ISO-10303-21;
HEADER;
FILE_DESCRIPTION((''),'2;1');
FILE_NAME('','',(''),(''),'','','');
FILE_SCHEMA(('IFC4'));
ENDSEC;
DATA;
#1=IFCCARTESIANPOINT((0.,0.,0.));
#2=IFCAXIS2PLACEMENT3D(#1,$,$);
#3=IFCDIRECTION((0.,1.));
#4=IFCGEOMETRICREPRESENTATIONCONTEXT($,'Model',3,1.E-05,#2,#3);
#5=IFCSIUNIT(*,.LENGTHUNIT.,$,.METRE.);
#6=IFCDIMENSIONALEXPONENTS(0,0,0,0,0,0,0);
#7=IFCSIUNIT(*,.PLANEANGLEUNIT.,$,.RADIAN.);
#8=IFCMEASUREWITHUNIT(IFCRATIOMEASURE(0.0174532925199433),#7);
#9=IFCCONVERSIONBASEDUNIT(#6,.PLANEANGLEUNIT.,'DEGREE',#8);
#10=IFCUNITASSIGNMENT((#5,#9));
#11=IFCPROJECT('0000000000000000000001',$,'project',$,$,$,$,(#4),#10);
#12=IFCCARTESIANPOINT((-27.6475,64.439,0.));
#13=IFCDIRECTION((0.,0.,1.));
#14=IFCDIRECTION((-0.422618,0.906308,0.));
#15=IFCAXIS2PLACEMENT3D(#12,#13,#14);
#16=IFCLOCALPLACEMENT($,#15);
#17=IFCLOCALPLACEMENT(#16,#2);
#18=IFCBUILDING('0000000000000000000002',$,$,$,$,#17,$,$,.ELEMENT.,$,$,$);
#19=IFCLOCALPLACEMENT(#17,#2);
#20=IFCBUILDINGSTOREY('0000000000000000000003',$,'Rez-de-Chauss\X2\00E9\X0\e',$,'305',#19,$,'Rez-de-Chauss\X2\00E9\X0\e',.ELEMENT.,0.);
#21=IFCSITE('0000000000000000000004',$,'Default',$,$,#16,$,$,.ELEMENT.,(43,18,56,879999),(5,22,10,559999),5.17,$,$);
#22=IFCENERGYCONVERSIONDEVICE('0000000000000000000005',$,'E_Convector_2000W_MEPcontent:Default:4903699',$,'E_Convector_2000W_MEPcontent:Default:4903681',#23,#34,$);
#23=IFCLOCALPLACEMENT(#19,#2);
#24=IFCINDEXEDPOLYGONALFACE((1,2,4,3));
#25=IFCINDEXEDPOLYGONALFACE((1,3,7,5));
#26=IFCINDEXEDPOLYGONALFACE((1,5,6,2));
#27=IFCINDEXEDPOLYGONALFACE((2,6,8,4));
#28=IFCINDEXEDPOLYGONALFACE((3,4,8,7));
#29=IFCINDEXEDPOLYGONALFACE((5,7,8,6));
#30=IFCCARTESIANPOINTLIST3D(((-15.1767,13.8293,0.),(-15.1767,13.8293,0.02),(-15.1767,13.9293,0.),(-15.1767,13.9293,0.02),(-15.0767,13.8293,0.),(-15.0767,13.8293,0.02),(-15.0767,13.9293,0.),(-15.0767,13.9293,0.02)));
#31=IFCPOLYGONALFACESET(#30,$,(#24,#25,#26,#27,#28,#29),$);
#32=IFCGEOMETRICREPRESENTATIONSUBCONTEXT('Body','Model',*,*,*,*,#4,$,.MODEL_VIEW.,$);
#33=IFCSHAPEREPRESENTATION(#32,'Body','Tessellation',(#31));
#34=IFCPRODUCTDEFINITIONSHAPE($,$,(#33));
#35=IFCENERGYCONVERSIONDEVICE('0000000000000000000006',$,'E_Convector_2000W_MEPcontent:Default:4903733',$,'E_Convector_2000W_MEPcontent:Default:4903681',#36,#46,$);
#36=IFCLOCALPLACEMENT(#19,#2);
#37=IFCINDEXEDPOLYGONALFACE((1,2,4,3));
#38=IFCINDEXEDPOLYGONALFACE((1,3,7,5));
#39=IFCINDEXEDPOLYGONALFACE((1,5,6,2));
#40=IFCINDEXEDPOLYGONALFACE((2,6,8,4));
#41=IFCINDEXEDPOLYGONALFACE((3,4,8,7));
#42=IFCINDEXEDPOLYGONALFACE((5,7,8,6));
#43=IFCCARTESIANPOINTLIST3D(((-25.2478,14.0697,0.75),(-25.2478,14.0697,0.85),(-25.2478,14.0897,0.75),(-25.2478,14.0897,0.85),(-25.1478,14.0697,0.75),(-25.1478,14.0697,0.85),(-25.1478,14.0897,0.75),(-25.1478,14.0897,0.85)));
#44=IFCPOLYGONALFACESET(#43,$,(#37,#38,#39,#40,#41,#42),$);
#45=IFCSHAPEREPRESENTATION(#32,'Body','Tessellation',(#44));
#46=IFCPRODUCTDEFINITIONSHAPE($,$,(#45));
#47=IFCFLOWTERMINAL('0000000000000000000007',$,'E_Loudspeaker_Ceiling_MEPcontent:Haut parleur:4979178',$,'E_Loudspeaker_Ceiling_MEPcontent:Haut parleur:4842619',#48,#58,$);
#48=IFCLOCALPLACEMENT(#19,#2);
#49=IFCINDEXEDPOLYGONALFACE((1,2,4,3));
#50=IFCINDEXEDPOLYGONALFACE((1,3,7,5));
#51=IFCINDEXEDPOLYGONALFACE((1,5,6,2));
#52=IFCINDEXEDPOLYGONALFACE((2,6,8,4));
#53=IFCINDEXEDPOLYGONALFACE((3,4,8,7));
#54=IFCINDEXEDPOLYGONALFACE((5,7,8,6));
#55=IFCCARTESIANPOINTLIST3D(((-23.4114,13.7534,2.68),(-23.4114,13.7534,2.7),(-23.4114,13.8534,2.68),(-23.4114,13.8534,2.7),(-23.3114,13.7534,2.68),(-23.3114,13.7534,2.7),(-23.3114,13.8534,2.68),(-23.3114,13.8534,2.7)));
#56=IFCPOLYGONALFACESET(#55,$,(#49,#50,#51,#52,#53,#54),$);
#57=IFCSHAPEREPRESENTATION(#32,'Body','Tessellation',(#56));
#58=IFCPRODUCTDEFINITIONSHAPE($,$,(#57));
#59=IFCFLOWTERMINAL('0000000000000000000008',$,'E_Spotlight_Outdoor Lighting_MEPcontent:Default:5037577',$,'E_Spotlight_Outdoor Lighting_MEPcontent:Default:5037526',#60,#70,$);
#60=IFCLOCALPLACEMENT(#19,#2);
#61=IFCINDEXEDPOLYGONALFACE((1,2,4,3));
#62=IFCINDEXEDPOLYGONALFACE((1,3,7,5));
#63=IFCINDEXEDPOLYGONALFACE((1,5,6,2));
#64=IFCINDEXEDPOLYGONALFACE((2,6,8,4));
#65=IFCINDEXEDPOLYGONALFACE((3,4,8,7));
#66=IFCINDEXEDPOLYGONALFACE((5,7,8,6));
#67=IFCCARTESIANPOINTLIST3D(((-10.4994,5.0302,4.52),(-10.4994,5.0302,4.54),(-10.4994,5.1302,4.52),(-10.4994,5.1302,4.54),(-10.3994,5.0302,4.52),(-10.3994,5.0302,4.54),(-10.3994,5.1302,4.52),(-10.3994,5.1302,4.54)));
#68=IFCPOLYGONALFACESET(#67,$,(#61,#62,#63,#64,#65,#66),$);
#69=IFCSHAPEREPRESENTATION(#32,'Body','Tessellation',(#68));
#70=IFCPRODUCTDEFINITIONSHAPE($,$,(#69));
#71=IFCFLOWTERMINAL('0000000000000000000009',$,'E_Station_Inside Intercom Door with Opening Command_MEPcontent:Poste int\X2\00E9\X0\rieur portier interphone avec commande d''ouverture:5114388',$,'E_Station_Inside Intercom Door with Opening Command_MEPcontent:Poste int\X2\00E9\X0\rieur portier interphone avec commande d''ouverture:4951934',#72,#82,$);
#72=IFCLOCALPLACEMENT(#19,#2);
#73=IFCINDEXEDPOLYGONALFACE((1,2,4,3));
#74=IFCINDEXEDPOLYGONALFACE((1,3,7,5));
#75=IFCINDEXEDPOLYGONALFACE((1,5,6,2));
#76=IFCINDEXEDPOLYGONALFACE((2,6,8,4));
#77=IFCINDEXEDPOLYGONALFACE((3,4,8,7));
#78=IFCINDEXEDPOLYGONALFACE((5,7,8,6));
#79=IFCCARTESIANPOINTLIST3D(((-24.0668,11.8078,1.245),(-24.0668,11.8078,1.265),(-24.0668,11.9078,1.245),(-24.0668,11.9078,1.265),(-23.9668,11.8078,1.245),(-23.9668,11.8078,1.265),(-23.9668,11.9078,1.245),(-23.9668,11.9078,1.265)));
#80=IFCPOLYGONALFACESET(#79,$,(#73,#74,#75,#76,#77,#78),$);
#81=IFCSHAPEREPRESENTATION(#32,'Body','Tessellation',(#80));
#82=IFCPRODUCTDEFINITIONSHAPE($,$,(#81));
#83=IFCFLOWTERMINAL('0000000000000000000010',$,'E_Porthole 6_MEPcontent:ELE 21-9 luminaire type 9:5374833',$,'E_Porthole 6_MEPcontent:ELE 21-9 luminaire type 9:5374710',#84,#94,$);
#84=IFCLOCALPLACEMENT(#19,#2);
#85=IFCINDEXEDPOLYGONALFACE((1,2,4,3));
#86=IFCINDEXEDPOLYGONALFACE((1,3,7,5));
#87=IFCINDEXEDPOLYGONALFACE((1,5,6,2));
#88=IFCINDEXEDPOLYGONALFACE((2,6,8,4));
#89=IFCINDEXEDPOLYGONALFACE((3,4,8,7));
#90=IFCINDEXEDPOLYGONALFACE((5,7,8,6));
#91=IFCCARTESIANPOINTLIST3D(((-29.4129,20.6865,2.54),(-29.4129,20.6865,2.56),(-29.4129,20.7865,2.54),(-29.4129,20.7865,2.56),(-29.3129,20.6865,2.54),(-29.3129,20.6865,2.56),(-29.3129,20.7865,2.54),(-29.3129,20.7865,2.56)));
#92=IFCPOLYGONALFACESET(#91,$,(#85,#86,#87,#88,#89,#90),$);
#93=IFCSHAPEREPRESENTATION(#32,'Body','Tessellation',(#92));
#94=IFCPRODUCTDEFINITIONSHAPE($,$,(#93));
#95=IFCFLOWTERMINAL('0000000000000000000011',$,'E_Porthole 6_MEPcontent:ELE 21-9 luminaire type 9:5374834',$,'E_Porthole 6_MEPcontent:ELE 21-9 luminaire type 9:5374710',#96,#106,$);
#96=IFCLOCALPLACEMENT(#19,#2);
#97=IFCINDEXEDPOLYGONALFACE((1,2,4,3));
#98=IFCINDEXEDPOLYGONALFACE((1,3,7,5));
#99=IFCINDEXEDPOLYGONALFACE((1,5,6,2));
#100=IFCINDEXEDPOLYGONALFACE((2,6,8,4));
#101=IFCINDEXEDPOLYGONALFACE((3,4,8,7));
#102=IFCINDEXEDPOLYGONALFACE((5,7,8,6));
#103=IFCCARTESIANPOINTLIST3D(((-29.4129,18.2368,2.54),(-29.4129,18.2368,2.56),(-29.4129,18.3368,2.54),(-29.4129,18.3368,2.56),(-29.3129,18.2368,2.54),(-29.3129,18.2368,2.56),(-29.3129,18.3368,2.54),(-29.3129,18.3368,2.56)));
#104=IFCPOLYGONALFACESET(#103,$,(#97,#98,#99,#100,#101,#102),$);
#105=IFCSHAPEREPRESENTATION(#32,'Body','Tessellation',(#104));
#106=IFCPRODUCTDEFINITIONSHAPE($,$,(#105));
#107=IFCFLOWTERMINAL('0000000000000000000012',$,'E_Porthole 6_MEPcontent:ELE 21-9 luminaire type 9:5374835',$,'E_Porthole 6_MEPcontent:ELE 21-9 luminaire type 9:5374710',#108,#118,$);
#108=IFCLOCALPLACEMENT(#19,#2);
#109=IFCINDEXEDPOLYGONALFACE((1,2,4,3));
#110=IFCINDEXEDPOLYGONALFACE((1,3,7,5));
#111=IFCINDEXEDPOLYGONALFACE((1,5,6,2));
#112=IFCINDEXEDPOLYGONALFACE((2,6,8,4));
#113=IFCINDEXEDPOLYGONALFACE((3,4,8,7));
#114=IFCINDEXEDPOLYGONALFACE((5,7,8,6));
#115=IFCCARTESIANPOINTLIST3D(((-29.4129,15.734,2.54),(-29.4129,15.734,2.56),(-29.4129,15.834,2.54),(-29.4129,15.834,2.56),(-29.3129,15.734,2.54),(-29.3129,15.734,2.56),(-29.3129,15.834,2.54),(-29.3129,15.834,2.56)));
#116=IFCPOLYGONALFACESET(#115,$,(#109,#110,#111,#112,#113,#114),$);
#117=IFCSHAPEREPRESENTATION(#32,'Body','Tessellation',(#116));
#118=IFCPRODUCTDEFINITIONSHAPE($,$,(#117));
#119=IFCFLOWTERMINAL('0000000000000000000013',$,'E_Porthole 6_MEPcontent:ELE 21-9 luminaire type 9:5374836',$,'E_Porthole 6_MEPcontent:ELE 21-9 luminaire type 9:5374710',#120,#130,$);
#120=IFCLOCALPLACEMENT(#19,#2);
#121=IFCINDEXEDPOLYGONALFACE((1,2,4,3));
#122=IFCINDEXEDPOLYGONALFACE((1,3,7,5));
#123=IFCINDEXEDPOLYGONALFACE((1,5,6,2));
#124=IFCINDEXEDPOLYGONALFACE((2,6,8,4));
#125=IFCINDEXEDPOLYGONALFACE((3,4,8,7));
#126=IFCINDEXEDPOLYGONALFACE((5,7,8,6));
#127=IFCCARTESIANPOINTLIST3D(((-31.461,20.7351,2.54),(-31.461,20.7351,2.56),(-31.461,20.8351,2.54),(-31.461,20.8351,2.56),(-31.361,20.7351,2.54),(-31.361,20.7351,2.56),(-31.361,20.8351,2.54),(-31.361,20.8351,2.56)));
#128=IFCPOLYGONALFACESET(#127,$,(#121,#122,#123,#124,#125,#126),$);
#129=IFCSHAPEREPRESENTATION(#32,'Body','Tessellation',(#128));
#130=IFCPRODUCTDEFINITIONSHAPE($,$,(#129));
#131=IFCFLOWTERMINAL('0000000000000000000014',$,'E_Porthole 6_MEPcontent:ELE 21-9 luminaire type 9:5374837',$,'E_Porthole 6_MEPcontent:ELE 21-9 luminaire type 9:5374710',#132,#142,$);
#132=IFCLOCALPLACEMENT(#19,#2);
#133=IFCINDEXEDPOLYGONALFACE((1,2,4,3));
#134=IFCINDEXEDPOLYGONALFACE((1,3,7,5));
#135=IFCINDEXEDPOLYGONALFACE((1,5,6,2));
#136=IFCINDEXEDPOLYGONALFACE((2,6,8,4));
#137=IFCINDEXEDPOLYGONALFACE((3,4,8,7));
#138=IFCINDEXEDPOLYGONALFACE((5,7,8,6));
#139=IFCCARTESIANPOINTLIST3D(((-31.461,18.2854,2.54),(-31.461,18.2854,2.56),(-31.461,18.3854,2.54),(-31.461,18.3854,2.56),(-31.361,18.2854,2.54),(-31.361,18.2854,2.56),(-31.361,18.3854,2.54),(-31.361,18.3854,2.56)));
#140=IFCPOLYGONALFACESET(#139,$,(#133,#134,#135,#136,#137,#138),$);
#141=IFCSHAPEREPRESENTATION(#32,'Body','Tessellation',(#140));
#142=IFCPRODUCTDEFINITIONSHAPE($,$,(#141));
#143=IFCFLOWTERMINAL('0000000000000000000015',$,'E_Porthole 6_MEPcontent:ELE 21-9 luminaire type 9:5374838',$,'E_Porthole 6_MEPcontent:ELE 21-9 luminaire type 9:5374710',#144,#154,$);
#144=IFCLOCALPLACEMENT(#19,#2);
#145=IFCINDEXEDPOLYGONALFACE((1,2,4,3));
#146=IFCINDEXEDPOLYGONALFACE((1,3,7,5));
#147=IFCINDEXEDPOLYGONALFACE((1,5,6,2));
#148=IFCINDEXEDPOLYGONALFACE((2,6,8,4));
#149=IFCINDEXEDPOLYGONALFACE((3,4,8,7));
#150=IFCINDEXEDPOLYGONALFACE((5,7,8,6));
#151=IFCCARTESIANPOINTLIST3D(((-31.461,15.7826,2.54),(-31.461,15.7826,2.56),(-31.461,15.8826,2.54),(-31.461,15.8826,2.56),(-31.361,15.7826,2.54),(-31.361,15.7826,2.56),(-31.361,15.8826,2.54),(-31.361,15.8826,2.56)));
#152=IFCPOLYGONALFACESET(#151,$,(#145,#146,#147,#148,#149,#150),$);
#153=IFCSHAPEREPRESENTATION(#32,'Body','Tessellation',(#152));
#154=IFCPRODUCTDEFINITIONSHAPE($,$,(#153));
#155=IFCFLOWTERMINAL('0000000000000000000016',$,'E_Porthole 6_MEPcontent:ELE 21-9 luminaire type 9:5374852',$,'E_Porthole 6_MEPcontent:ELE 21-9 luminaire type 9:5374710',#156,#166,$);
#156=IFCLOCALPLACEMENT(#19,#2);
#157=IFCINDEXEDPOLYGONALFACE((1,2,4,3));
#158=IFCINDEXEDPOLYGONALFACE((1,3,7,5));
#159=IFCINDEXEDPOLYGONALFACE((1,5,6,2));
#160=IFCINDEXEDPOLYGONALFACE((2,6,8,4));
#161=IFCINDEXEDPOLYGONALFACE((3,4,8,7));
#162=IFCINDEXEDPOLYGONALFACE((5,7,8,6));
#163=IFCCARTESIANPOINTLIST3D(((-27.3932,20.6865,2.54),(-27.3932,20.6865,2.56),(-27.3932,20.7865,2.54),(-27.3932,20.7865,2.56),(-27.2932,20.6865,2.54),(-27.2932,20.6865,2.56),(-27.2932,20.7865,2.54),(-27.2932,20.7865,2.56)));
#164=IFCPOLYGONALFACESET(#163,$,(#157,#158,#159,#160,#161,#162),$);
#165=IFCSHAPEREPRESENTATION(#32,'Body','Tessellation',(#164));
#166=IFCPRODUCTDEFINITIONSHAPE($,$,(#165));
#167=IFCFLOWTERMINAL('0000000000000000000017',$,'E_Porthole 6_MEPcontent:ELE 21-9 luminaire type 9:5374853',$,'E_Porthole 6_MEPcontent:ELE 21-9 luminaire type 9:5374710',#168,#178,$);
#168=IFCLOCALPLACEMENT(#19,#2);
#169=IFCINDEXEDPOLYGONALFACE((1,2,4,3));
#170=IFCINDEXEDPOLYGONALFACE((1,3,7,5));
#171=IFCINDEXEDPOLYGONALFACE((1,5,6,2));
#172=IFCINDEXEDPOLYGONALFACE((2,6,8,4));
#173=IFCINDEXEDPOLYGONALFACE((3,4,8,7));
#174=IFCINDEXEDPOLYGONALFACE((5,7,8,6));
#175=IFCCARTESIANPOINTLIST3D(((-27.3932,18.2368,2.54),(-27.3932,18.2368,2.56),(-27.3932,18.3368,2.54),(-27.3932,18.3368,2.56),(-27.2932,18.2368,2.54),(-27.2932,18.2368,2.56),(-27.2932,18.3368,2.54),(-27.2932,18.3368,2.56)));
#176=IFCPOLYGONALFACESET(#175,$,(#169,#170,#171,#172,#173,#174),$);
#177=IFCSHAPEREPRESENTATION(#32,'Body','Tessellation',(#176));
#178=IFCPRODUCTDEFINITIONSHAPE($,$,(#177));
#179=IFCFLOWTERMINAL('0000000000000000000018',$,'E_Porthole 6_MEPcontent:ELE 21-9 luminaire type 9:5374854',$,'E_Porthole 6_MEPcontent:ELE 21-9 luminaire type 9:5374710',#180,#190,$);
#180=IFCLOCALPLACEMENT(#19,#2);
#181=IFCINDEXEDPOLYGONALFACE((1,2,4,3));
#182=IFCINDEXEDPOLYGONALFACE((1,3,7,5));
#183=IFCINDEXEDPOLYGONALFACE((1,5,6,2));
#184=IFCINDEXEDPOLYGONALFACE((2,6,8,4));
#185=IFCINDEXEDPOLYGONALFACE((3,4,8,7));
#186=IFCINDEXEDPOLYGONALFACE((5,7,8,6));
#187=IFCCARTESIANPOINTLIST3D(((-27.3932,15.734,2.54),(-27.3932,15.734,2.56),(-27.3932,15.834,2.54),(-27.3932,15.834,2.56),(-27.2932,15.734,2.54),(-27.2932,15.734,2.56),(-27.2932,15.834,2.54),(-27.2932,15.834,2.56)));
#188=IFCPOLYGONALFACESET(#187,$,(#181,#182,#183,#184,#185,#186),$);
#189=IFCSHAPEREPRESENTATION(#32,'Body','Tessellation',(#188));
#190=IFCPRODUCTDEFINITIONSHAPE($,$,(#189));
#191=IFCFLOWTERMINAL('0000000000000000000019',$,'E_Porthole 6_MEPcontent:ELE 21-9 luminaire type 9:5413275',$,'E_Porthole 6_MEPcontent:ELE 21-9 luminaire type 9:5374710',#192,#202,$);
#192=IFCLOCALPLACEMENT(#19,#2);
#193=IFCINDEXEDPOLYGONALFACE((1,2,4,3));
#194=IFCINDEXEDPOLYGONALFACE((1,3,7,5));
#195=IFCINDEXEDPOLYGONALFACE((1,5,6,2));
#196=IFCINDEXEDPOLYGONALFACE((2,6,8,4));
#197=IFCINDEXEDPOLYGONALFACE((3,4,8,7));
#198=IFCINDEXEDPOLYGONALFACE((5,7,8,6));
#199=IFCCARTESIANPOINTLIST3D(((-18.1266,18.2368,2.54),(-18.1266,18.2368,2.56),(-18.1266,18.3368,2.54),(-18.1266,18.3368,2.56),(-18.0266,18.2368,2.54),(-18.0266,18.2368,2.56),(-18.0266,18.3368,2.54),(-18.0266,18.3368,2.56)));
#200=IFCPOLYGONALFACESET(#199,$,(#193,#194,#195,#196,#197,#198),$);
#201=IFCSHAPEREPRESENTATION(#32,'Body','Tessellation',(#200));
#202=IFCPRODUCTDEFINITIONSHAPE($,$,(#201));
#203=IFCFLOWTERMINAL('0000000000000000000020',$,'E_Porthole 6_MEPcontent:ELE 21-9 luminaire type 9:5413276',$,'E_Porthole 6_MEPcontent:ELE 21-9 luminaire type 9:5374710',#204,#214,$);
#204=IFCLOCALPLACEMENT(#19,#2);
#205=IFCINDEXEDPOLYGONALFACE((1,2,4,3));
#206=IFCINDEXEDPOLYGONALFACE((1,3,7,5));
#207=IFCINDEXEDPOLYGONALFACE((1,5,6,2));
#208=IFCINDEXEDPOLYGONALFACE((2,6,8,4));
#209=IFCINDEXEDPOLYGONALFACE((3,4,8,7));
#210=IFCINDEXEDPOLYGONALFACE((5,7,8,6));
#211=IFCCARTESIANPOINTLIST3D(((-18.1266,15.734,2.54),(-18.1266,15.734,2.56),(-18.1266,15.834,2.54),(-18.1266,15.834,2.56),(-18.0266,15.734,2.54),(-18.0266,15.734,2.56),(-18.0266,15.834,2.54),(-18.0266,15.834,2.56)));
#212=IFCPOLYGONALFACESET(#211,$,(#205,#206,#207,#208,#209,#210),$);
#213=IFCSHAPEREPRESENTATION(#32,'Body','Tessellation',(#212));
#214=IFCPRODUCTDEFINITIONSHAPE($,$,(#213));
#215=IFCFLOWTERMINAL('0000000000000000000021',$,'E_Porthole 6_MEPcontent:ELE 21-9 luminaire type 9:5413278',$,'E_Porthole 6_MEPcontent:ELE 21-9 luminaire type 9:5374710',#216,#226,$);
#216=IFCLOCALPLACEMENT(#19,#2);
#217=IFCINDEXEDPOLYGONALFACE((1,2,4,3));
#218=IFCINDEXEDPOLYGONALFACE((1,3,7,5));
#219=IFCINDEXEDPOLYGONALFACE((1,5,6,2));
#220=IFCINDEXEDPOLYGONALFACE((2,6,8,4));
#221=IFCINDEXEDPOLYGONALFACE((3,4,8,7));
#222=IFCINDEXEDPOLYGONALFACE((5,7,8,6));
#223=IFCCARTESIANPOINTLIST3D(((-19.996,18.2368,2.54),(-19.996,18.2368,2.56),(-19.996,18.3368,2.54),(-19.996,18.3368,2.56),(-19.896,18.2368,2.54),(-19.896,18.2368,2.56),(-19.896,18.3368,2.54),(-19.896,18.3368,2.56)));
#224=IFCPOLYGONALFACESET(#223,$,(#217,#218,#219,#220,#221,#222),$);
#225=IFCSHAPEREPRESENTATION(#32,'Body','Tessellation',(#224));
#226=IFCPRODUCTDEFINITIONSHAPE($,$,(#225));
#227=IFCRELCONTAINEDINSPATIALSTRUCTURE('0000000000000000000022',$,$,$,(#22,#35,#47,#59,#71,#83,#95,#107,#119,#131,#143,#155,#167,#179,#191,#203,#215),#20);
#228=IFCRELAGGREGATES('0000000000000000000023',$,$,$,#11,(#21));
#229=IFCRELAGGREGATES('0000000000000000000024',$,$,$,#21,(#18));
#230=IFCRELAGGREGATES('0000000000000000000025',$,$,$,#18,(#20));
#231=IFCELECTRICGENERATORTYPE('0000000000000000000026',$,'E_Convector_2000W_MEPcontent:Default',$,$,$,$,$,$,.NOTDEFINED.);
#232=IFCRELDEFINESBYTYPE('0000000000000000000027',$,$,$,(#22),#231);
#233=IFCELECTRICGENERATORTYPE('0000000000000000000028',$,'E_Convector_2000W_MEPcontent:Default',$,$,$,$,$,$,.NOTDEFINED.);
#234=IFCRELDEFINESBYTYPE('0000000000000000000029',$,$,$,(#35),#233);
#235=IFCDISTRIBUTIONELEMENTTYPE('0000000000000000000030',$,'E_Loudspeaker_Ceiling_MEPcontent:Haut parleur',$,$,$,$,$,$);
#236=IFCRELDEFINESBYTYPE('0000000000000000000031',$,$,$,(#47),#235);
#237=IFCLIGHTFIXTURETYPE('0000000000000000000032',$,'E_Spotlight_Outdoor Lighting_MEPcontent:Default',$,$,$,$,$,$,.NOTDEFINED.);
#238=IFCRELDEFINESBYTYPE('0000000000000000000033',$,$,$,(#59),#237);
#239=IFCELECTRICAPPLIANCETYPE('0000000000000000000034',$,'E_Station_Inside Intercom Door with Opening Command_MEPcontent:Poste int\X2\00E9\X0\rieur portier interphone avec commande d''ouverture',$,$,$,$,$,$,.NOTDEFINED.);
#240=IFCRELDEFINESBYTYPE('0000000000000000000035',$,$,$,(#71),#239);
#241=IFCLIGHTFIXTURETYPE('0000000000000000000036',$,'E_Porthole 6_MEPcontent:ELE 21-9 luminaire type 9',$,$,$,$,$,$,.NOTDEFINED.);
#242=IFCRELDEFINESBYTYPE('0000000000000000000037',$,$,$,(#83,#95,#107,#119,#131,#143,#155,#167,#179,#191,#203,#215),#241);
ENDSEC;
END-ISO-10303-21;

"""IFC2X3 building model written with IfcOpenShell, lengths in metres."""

from ifc_helpers import new_model, entity, si_unit, converted_unit, direction, frame, frame_2d, origin, origin_2d_with_axis, place, context, subcontext, project, spatial, rectangle, extrude, source, transform, mapped, type_object, type_shapes, element, save


model = new_model("IFC2X3")

# Units and contexts
model_context = context("Model", 3, precision=1e-05, world=origin(), true_north=direction((0.0, 1.0)))
body_context = subcontext(model_context, "Body", "Model", "MODEL_VIEW")
ifc_project = project(units=[si_unit("LENGTHUNIT", "METRE"), converted_unit("PLANEANGLEUNIT", "DEGREE", entity("IfcRatioMeasure", 0.0174532925199433), si_unit("PLANEANGLEUNIT", "RADIAN"), dimensions=[0, 0, 0, 0, 0, 0, 0])], contexts=[model_context])

# Site, building, storey
site_placement = place(None, frame((-27.6475, 64.439, 0.0), z_axis=(0.0, 0.0, 1.0), x_axis=(-0.422618, 0.906308, 0.0)))
site = spatial("IfcSite", under=ifc_project, at=site_placement, Name="Default", CompositionType="ELEMENT", RefLatitude=(43, 18, 56, 879999), RefLongitude=(5, 22, 10, 559999), RefElevation=5.17)
building_placement = place(site_placement, origin())
building = spatial("IfcBuilding", under=site, at=building_placement, CompositionType="ELEMENT")
storey_placement = place(building_placement, origin())
storey = spatial("IfcBuildingStorey", under=building, at=storey_placement, Name="Rez-de-Chaussée", ObjectType="305", LongName="Rez-de-Chaussée", CompositionType="ELEMENT", Elevation=0.0)

# Energy conversion devices
electric_generator_type_1 = type_object("IfcElectricGeneratorType", Name="E_Convector_2000W_MEPcontent:Default", PredefinedType="NOTDEFINED")
shared_shape_1 = source(origin(), body_context, "Body", "SweptSolid", [
    extrude(rectangle(XDim=0.1, YDim=0.1, at=origin_2d_with_axis()), frame((0.0, 0.0, 0.0), z_axis=(0.0, 0.0, 1.0), x_axis=(0.0, -1.0, 0.0)), (0.0, 0.0, 1.0), 0.02),
])
type_shapes(electric_generator_type_1, [shared_shape_1])
energy_conversion_device_1_placement = place(storey_placement, frame((-15.1267, 13.8793, 0.0)))
element("IfcEnergyConversionDevice", 1, at=energy_conversion_device_1_placement, inside=storey, type_object=electric_generator_type_1, Name="E_Convector_2000W_MEPcontent:Default:4903699", ObjectType="E_Convector_2000W_MEPcontent:Default:4903681", context=body_context, shape_type="MappedRepresentation", body=[
    mapped(shared_shape_1, transform((0.0, 0.0, 0.0), scale=1.0)),
])
electric_generator_type_2 = type_object("IfcElectricGeneratorType", Name="E_Convector_2000W_MEPcontent:Default", PredefinedType="NOTDEFINED")
shared_shape_2 = source(origin(), body_context, "Body", "SweptSolid", [
    extrude(rectangle(XDim=0.02, YDim=0.1, at=frame_2d((0.0, 0.0), x_axis=(1.0, 0.0))), frame((0.0, 0.01, -0.05), z_axis=(0.0, 0.0, 1.0), x_axis=(0.0, -1.0, 0.0)), (0.0, 0.0, 1.0), 0.1),
])
type_shapes(electric_generator_type_2, [shared_shape_2])
energy_conversion_device_2_placement = place(storey_placement, frame((-25.1978, 14.0897, 0.8), z_axis=(0.0, 0.0, 1.0), x_axis=(-1.0, 0.0, 0.0)))
element("IfcEnergyConversionDevice", 2, at=energy_conversion_device_2_placement, inside=storey, type_object=electric_generator_type_2, Name="E_Convector_2000W_MEPcontent:Default:4903733", ObjectType="E_Convector_2000W_MEPcontent:Default:4903681", context=body_context, shape_type="MappedRepresentation", body=[
    mapped(shared_shape_2, transform((0.0, 0.0, 0.0), scale=1.0)),
])

# Flow terminals
distribution_element_type_1 = type_object("IfcDistributionElementType", Name="E_Loudspeaker_Ceiling_MEPcontent:Haut parleur")
shared_shape_3 = source(origin(), body_context, "Body", "SweptSolid", [
    extrude(rectangle(XDim=0.1, YDim=0.1, at=origin_2d_with_axis()), frame((0.0, 0.0, -0.02)), (0.0, 0.0, 1.0), 0.02),
])
type_shapes(distribution_element_type_1, [shared_shape_3])
flow_terminal_1_placement = place(storey_placement, frame((-23.3614, 13.8034, 2.7), z_axis=(0.0, 0.0, 1.0), x_axis=(0.0, -1.0, 0.0)))
element("IfcFlowTerminal", 3, at=flow_terminal_1_placement, inside=storey, type_object=distribution_element_type_1, Name="E_Loudspeaker_Ceiling_MEPcontent:Haut parleur:4979178", ObjectType="E_Loudspeaker_Ceiling_MEPcontent:Haut parleur:4842619", context=body_context, shape_type="MappedRepresentation", body=[
    mapped(shared_shape_3, transform((0.0, 0.0, 0.0), scale=1.0)),
])
light_fixture_type_1 = type_object("IfcLightFixtureType", Name="E_Spotlight_Outdoor Lighting_MEPcontent:Default", PredefinedType="NOTDEFINED")
shared_shape_4 = source(origin(), body_context, "Body", "SweptSolid", [
    extrude(rectangle(XDim=0.1, YDim=0.1, at=origin_2d_with_axis()), frame((0.0, 0.0, 0.0), z_axis=(0.0, 0.0, 1.0), x_axis=(0.0, -1.0, 0.0)), (0.0, 0.0, 1.0), 0.02),
])
type_shapes(light_fixture_type_1, [shared_shape_4])
flow_terminal_2_placement = place(storey_placement, frame((-10.4494, 5.0802, 4.52), z_axis=(0.0, 0.0, 1.0), x_axis=(0.0, -1.0, 0.0)))
element("IfcFlowTerminal", 4, at=flow_terminal_2_placement, inside=storey, type_object=light_fixture_type_1, Name="E_Spotlight_Outdoor Lighting_MEPcontent:Default:5037577", ObjectType="E_Spotlight_Outdoor Lighting_MEPcontent:Default:5037526", context=body_context, shape_type="MappedRepresentation", body=[
    mapped(shared_shape_4, transform((0.0, 0.0, 0.0), scale=1.0)),
])
electric_appliance_type = type_object("IfcElectricApplianceType", Name="E_Station_Inside Intercom Door with Opening Command_MEPcontent:Poste intérieur portier interphone avec commande d'ouverture", PredefinedType="NOTDEFINED")
shared_shape_5 = source(origin(), body_context, "Body", "SweptSolid", [
    extrude(rectangle(XDim=0.1, YDim=0.1, at=origin_2d_with_axis()), frame((0.0, 0.0, 0.0), z_axis=(0.0, 0.0, 1.0), x_axis=(0.0, -1.0, 0.0)), (0.0, 0.0, 1.0), 0.02),
])
type_shapes(electric_appliance_type, [shared_shape_5])
flow_terminal_3_placement = place(storey_placement, frame((-24.0168, 11.8578, 1.245), z_axis=(0.0, 0.0, 1.0), x_axis=(0.0, 1.0, 0.0)))
element("IfcFlowTerminal", 5, at=flow_terminal_3_placement, inside=storey, type_object=electric_appliance_type, Name="E_Station_Inside Intercom Door with Opening Command_MEPcontent:Poste intérieur portier interphone avec commande d'ouverture:5114388", ObjectType="E_Station_Inside Intercom Door with Opening Command_MEPcontent:Poste intérieur portier interphone avec commande d'ouverture:4951934", context=body_context, shape_type="MappedRepresentation", body=[
    mapped(shared_shape_5, transform((0.0, 0.0, 0.0), scale=1.0)),
])
light_fixture_type_2 = type_object("IfcLightFixtureType", Name="E_Porthole 6_MEPcontent:ELE 21-9 luminaire type 9", PredefinedType="NOTDEFINED")
shared_shape_6 = source(origin(), body_context, "Body", "SweptSolid", [
    extrude(rectangle(XDim=0.1, YDim=0.1, at=origin_2d_with_axis()), frame((0.0, 0.0, 0.0), z_axis=(0.0, 0.0, 1.0), x_axis=(0.0, -1.0, 0.0)), (0.0, 0.0, 1.0), 0.02),
])
type_shapes(light_fixture_type_2, [shared_shape_6])
for number, where, z_axis, x_axis, name in (
    (6, (-29.3629, 20.7365, 2.54), (0.0, 0.0, 1.0), (0.0, -1.0, 0.0), "E_Porthole 6_MEPcontent:ELE 21-9 luminaire type 9:5374833"),
    (7, (-29.3629, 18.2868, 2.54), (0.0, 0.0, 1.0), (0.0, -1.0, 0.0), "E_Porthole 6_MEPcontent:ELE 21-9 luminaire type 9:5374834"),
    (8, (-29.3629, 15.784, 2.54), (0.0, 0.0, 1.0), (0.0, -1.0, 0.0), "E_Porthole 6_MEPcontent:ELE 21-9 luminaire type 9:5374835"),
    (9, (-31.411, 20.7851, 2.54), (0.0, 0.0, 1.0), (0.0, -1.0, 0.0), "E_Porthole 6_MEPcontent:ELE 21-9 luminaire type 9:5374836"),
    (10, (-31.411, 18.3354, 2.54), (0.0, 0.0, 1.0), (0.0, -1.0, 0.0), "E_Porthole 6_MEPcontent:ELE 21-9 luminaire type 9:5374837"),
    (11, (-31.411, 15.8326, 2.54), (0.0, 0.0, 1.0), (0.0, -1.0, 0.0), "E_Porthole 6_MEPcontent:ELE 21-9 luminaire type 9:5374838"),
    (12, (-27.3432, 20.7365, 2.54), (0.0, 0.0, 1.0), (0.0, -1.0, 0.0), "E_Porthole 6_MEPcontent:ELE 21-9 luminaire type 9:5374852"),
    (13, (-27.3432, 18.2868, 2.54), (0.0, 0.0, 1.0), (0.0, -1.0, 0.0), "E_Porthole 6_MEPcontent:ELE 21-9 luminaire type 9:5374853"),
    (14, (-27.3432, 15.784, 2.54), (0.0, 0.0, 1.0), (0.0, -1.0, 0.0), "E_Porthole 6_MEPcontent:ELE 21-9 luminaire type 9:5374854"),
    (15, (-18.0766, 18.2868, 2.54), (0.0, 0.0, 1.0), (0.0, -1.0, 0.0), "E_Porthole 6_MEPcontent:ELE 21-9 luminaire type 9:5413275"),
    (16, (-18.0766, 15.784, 2.54), (0.0, 0.0, 1.0), (0.0, -1.0, 0.0), "E_Porthole 6_MEPcontent:ELE 21-9 luminaire type 9:5413276"),
    (17, (-19.946, 18.2868, 2.54), (0.0, 0.0, 1.0), (0.0, -1.0, 0.0), "E_Porthole 6_MEPcontent:ELE 21-9 luminaire type 9:5413278"),
):
    element("IfcFlowTerminal", number, at=place(storey_placement, frame(where, z_axis=z_axis, x_axis=x_axis)), inside=storey, type_object=light_fixture_type_2, Name=name, ObjectType="E_Porthole 6_MEPcontent:ELE 21-9 luminaire type 9:5374710", context=body_context, shape_type="MappedRepresentation", body=[
        mapped(shared_shape_6, transform((0.0, 0.0, 0.0), scale=1.0)),
    ])

save(model, "model.ifc")
